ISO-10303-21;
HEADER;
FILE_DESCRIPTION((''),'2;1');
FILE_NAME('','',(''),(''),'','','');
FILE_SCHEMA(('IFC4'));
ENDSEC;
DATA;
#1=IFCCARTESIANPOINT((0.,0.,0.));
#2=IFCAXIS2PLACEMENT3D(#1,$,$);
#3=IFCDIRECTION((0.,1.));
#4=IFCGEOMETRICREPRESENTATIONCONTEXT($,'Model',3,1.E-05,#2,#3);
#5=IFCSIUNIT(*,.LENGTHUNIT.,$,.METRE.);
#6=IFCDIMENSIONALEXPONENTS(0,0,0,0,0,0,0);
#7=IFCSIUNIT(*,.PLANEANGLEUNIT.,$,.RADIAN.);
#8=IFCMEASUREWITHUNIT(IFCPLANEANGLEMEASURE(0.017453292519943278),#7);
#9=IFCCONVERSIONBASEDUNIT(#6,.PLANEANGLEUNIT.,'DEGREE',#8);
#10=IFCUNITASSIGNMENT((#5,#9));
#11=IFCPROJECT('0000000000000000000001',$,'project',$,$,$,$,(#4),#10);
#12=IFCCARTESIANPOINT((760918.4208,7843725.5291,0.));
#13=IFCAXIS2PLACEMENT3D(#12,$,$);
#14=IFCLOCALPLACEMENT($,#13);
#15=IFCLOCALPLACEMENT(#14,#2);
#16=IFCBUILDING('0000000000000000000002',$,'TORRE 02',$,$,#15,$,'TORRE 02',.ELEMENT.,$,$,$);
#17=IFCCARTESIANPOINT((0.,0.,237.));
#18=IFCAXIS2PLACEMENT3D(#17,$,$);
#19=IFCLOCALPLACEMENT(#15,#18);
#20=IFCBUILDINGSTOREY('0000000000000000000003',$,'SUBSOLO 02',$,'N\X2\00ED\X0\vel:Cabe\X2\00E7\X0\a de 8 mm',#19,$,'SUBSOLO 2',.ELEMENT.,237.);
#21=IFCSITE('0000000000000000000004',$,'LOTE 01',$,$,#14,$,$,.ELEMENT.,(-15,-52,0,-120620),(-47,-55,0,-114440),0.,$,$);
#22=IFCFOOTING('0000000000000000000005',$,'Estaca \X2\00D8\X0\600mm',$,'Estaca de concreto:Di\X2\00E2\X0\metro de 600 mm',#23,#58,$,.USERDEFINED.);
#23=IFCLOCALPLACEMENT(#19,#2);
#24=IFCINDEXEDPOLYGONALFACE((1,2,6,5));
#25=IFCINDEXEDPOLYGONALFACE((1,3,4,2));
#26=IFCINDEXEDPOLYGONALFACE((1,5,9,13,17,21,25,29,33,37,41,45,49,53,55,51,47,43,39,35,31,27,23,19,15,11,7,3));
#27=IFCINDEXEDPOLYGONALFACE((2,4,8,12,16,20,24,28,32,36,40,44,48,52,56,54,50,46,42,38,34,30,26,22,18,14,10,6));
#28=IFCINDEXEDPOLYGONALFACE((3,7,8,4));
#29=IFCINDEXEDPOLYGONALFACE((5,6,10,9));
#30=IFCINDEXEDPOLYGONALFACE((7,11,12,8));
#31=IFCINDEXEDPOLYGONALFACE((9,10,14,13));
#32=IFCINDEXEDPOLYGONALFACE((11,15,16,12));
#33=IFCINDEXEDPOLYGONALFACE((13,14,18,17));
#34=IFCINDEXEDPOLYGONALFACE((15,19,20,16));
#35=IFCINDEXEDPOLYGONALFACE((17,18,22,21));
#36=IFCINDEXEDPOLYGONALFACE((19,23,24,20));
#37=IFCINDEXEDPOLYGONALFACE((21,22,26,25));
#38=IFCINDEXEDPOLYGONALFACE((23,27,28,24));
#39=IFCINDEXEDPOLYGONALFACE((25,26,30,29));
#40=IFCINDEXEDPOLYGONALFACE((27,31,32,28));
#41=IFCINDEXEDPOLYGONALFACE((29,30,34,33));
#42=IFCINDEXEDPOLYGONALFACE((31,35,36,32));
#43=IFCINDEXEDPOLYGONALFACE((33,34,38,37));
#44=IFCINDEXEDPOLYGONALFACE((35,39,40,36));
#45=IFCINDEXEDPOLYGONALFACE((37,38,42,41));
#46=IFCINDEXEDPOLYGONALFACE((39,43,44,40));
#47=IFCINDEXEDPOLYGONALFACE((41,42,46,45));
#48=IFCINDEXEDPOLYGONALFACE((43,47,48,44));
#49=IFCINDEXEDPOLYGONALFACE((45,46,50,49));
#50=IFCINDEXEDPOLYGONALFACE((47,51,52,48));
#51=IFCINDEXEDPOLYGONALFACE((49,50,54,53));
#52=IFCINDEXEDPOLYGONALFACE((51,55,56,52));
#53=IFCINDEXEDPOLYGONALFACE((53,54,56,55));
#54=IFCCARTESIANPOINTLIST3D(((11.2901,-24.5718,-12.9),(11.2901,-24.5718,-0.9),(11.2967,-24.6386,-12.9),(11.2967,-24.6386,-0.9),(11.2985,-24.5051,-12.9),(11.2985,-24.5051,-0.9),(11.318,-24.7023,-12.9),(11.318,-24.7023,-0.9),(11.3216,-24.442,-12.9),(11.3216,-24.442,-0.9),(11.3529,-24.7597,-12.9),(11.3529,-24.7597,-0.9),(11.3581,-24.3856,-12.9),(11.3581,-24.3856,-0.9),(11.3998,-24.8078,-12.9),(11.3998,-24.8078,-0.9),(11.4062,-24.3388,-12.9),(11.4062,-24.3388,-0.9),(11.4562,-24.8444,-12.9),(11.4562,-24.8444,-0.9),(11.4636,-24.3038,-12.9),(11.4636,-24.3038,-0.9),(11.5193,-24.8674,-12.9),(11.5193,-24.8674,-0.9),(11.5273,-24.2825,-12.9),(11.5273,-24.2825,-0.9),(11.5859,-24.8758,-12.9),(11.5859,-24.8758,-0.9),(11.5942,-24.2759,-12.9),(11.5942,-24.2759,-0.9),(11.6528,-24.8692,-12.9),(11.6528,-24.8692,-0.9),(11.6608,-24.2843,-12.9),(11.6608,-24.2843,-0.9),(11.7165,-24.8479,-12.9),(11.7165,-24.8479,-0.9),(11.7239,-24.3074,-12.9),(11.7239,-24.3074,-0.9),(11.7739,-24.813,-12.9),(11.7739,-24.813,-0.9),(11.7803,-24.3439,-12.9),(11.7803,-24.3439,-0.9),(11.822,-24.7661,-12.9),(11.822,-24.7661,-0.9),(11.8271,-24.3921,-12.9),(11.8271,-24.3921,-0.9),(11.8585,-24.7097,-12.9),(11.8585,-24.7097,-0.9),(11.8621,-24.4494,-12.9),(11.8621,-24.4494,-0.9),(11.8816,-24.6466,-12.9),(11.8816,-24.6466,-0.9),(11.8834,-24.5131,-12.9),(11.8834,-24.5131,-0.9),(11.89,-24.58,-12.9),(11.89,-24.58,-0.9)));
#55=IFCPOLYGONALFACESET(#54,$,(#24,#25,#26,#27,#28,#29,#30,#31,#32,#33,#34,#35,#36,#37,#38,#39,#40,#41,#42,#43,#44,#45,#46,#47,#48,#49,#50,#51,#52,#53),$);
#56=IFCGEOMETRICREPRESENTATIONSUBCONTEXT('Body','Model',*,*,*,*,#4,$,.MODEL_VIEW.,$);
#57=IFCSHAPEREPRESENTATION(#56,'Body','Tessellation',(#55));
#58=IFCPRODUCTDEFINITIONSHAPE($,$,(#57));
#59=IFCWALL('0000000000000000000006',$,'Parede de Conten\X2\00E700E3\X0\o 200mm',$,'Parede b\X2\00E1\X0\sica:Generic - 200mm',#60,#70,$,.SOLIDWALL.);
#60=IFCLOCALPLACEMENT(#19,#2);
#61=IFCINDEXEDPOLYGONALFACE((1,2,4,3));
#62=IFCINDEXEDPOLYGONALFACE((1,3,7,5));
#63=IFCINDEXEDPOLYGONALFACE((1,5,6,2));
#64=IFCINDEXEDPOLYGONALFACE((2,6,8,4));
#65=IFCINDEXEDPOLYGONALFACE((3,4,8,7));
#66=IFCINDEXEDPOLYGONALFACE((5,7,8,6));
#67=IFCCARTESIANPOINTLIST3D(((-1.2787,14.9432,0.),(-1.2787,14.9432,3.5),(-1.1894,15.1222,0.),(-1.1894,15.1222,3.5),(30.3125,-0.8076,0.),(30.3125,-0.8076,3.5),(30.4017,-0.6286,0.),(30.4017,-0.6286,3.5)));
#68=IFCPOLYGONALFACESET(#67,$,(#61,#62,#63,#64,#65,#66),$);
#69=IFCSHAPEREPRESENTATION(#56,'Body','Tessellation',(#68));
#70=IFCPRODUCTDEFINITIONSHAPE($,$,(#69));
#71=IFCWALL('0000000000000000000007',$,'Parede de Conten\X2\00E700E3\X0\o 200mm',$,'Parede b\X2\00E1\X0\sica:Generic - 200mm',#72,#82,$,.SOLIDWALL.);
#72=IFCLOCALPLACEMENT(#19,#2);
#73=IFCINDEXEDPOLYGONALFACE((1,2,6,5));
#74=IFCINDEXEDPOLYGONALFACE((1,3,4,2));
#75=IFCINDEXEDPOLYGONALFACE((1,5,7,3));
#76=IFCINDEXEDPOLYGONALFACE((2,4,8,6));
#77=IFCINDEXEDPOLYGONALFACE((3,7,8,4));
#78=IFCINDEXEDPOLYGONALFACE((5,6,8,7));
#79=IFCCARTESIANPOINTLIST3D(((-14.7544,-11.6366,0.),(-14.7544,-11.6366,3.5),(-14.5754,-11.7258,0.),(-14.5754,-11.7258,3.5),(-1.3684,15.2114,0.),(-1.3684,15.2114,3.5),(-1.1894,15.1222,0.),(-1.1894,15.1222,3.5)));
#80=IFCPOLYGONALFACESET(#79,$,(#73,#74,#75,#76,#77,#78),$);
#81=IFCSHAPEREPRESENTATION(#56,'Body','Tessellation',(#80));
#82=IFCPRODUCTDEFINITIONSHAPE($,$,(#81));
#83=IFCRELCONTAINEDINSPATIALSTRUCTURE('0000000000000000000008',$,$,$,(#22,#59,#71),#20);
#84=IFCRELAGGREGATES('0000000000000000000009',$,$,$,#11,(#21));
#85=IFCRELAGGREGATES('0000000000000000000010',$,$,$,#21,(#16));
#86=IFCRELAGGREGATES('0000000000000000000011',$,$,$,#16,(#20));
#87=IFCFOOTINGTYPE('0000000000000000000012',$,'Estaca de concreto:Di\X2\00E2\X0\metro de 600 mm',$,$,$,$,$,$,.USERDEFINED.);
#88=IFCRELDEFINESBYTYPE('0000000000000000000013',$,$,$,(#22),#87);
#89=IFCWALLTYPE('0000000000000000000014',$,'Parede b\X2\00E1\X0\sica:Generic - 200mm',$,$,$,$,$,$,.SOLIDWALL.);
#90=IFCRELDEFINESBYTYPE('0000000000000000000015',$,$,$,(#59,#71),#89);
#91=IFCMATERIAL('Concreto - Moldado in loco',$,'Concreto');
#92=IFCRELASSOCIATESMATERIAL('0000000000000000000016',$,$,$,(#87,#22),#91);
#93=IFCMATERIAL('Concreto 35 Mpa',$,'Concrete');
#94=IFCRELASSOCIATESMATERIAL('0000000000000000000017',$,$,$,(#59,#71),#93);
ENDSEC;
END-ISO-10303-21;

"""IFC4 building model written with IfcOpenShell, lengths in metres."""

from ifc_helpers import new_model, entity, si_unit, converted_unit, direction, frame, origin, place, context, subcontext, project, spatial, arc, indexed_curve, outline, extrude, source, transform, mapped, material, type_object, type_shapes, element, save


model = new_model("IFC4")

# Units and contexts
model_context = context("Model", 3, precision=1e-05, world=origin(), true_north=direction((0.0, 1.0)))
body_context = subcontext(model_context, "Body", "Model", "MODEL_VIEW")
ifc_project = project(units=[si_unit("LENGTHUNIT", "METRE"), converted_unit("PLANEANGLEUNIT", "DEGREE", entity("IfcPlaneAngleMeasure", 0.017453292519943278), si_unit("PLANEANGLEUNIT", "RADIAN"), dimensions=[0, 0, 0, 0, 0, 0, 0])], contexts=[model_context])

# Site, building, storey
site_placement = place(None, frame((760918.4208, 7843725.5291, 0.0)))
site = spatial("IfcSite", under=ifc_project, at=site_placement, Name="LOTE 01", CompositionType="ELEMENT", RefLatitude=(-15, -52, 0, -120620), RefLongitude=(-47, -55, 0, -114440), RefElevation=0.0)
building_placement = place(site_placement, origin())
building = spatial("IfcBuilding", under=site, at=building_placement, Name="TORRE 02", LongName="TORRE 02", CompositionType="ELEMENT")
storey_placement = place(building_placement, frame((0.0, 0.0, 237.0)))
storey = spatial("IfcBuildingStorey", under=building, at=storey_placement, Name="SUBSOLO 02", ObjectType="Nível:Cabeça de 8 mm", LongName="SUBSOLO 2", CompositionType="ELEMENT", Elevation=237.0)

# Footing
ifc_material_1 = material(Name="Concreto - Moldado in loco", Category="Concreto")
placement = place(building_placement, frame((0.0, 0.0, 237.0)))
footing_type_1 = type_object("IfcFootingType", Name="Estaca de concreto:Diâmetro de 600 mm", PredefinedType="USERDEFINED", material=ifc_material_1)
shared_shape_1 = source(origin(), body_context, "Body", "SweptSolid", [
    extrude(outline(indexed_curve([(-0.3, 0.0), (0.0, -0.3), (0.3, 0.0), (0.0, 0.3)], segments=[arc(1, 2, 3), arc(3, 4, 1)], self_intersect=False)), frame((11.59, -24.5759, -12.0), z_axis=(0.0, 0.0, 1.0), x_axis=(-0.894934, 0.446198, 0.0)), (0.0, 0.0, 1.0), 12.0),
])
type_shapes(footing_type_1, [shared_shape_1])
footing_1_placement = place(placement, frame((0.0, 0.0, -0.9)))
element("IfcFooting", 1, at=footing_1_placement, inside=storey, type_object=footing_type_1, material=ifc_material_1, Name="Estaca Ø600mm", ObjectType="Estaca de concreto:Diâmetro de 600 mm", PredefinedType="USERDEFINED", context=body_context, shape_type="MappedRepresentation", body=[
    mapped(shared_shape_1, transform((0.0, 0.0, 0.0), scale=1.0)),
])

# Walls
ifc_material_2 = material(Name="Concreto 35 Mpa", Category="Concrete")
wall_type = type_object("IfcWallType", Name="Parede básica:Generic - 200mm", PredefinedType="SOLIDWALL")
wall_1_placement = place(placement, frame((-1.2341, 15.0327, 0.0), z_axis=(0.0, 0.0, 1.0), x_axis=(0.894934, -0.446198, 0.0)))
element("IfcWall", 2, at=wall_1_placement, inside=storey, type_object=wall_type, material=ifc_material_2, Name="Parede de Contenção 200mm", ObjectType="Parede básica:Generic - 200mm", PredefinedType="SOLIDWALL", context=body_context, shape_type="SweptSolid", body=[
    extrude(outline(indexed_curve([(35.3, 0.1), (0.0, 0.1), (0.0, -0.1), (35.3, -0.1), (35.3, 0.1)], self_intersect=False)), origin(), (0.0, 0.0, 1.0), 3.5),
])
wall_2_placement = place(placement, frame((-14.6649, -11.6812, 0.0), z_axis=(0.0, 0.0, 1.0), x_axis=(0.446198, 0.894934, 0.0)))
element("IfcWall", 3, at=wall_2_placement, inside=storey, type_object=wall_type, material=ifc_material_2, Name="Parede de Contenção 200mm", ObjectType="Parede básica:Generic - 200mm", PredefinedType="SOLIDWALL", context=body_context, shape_type="SweptSolid", body=[
    extrude(outline(indexed_curve([(30.0, 0.1), (0.0, 0.1), (0.0, -0.1), (30.0, -0.1), (30.0, 0.1)], self_intersect=False)), origin(), (0.0, 0.0, 1.0), 3.5),
])

save(model, "model.ifc")
